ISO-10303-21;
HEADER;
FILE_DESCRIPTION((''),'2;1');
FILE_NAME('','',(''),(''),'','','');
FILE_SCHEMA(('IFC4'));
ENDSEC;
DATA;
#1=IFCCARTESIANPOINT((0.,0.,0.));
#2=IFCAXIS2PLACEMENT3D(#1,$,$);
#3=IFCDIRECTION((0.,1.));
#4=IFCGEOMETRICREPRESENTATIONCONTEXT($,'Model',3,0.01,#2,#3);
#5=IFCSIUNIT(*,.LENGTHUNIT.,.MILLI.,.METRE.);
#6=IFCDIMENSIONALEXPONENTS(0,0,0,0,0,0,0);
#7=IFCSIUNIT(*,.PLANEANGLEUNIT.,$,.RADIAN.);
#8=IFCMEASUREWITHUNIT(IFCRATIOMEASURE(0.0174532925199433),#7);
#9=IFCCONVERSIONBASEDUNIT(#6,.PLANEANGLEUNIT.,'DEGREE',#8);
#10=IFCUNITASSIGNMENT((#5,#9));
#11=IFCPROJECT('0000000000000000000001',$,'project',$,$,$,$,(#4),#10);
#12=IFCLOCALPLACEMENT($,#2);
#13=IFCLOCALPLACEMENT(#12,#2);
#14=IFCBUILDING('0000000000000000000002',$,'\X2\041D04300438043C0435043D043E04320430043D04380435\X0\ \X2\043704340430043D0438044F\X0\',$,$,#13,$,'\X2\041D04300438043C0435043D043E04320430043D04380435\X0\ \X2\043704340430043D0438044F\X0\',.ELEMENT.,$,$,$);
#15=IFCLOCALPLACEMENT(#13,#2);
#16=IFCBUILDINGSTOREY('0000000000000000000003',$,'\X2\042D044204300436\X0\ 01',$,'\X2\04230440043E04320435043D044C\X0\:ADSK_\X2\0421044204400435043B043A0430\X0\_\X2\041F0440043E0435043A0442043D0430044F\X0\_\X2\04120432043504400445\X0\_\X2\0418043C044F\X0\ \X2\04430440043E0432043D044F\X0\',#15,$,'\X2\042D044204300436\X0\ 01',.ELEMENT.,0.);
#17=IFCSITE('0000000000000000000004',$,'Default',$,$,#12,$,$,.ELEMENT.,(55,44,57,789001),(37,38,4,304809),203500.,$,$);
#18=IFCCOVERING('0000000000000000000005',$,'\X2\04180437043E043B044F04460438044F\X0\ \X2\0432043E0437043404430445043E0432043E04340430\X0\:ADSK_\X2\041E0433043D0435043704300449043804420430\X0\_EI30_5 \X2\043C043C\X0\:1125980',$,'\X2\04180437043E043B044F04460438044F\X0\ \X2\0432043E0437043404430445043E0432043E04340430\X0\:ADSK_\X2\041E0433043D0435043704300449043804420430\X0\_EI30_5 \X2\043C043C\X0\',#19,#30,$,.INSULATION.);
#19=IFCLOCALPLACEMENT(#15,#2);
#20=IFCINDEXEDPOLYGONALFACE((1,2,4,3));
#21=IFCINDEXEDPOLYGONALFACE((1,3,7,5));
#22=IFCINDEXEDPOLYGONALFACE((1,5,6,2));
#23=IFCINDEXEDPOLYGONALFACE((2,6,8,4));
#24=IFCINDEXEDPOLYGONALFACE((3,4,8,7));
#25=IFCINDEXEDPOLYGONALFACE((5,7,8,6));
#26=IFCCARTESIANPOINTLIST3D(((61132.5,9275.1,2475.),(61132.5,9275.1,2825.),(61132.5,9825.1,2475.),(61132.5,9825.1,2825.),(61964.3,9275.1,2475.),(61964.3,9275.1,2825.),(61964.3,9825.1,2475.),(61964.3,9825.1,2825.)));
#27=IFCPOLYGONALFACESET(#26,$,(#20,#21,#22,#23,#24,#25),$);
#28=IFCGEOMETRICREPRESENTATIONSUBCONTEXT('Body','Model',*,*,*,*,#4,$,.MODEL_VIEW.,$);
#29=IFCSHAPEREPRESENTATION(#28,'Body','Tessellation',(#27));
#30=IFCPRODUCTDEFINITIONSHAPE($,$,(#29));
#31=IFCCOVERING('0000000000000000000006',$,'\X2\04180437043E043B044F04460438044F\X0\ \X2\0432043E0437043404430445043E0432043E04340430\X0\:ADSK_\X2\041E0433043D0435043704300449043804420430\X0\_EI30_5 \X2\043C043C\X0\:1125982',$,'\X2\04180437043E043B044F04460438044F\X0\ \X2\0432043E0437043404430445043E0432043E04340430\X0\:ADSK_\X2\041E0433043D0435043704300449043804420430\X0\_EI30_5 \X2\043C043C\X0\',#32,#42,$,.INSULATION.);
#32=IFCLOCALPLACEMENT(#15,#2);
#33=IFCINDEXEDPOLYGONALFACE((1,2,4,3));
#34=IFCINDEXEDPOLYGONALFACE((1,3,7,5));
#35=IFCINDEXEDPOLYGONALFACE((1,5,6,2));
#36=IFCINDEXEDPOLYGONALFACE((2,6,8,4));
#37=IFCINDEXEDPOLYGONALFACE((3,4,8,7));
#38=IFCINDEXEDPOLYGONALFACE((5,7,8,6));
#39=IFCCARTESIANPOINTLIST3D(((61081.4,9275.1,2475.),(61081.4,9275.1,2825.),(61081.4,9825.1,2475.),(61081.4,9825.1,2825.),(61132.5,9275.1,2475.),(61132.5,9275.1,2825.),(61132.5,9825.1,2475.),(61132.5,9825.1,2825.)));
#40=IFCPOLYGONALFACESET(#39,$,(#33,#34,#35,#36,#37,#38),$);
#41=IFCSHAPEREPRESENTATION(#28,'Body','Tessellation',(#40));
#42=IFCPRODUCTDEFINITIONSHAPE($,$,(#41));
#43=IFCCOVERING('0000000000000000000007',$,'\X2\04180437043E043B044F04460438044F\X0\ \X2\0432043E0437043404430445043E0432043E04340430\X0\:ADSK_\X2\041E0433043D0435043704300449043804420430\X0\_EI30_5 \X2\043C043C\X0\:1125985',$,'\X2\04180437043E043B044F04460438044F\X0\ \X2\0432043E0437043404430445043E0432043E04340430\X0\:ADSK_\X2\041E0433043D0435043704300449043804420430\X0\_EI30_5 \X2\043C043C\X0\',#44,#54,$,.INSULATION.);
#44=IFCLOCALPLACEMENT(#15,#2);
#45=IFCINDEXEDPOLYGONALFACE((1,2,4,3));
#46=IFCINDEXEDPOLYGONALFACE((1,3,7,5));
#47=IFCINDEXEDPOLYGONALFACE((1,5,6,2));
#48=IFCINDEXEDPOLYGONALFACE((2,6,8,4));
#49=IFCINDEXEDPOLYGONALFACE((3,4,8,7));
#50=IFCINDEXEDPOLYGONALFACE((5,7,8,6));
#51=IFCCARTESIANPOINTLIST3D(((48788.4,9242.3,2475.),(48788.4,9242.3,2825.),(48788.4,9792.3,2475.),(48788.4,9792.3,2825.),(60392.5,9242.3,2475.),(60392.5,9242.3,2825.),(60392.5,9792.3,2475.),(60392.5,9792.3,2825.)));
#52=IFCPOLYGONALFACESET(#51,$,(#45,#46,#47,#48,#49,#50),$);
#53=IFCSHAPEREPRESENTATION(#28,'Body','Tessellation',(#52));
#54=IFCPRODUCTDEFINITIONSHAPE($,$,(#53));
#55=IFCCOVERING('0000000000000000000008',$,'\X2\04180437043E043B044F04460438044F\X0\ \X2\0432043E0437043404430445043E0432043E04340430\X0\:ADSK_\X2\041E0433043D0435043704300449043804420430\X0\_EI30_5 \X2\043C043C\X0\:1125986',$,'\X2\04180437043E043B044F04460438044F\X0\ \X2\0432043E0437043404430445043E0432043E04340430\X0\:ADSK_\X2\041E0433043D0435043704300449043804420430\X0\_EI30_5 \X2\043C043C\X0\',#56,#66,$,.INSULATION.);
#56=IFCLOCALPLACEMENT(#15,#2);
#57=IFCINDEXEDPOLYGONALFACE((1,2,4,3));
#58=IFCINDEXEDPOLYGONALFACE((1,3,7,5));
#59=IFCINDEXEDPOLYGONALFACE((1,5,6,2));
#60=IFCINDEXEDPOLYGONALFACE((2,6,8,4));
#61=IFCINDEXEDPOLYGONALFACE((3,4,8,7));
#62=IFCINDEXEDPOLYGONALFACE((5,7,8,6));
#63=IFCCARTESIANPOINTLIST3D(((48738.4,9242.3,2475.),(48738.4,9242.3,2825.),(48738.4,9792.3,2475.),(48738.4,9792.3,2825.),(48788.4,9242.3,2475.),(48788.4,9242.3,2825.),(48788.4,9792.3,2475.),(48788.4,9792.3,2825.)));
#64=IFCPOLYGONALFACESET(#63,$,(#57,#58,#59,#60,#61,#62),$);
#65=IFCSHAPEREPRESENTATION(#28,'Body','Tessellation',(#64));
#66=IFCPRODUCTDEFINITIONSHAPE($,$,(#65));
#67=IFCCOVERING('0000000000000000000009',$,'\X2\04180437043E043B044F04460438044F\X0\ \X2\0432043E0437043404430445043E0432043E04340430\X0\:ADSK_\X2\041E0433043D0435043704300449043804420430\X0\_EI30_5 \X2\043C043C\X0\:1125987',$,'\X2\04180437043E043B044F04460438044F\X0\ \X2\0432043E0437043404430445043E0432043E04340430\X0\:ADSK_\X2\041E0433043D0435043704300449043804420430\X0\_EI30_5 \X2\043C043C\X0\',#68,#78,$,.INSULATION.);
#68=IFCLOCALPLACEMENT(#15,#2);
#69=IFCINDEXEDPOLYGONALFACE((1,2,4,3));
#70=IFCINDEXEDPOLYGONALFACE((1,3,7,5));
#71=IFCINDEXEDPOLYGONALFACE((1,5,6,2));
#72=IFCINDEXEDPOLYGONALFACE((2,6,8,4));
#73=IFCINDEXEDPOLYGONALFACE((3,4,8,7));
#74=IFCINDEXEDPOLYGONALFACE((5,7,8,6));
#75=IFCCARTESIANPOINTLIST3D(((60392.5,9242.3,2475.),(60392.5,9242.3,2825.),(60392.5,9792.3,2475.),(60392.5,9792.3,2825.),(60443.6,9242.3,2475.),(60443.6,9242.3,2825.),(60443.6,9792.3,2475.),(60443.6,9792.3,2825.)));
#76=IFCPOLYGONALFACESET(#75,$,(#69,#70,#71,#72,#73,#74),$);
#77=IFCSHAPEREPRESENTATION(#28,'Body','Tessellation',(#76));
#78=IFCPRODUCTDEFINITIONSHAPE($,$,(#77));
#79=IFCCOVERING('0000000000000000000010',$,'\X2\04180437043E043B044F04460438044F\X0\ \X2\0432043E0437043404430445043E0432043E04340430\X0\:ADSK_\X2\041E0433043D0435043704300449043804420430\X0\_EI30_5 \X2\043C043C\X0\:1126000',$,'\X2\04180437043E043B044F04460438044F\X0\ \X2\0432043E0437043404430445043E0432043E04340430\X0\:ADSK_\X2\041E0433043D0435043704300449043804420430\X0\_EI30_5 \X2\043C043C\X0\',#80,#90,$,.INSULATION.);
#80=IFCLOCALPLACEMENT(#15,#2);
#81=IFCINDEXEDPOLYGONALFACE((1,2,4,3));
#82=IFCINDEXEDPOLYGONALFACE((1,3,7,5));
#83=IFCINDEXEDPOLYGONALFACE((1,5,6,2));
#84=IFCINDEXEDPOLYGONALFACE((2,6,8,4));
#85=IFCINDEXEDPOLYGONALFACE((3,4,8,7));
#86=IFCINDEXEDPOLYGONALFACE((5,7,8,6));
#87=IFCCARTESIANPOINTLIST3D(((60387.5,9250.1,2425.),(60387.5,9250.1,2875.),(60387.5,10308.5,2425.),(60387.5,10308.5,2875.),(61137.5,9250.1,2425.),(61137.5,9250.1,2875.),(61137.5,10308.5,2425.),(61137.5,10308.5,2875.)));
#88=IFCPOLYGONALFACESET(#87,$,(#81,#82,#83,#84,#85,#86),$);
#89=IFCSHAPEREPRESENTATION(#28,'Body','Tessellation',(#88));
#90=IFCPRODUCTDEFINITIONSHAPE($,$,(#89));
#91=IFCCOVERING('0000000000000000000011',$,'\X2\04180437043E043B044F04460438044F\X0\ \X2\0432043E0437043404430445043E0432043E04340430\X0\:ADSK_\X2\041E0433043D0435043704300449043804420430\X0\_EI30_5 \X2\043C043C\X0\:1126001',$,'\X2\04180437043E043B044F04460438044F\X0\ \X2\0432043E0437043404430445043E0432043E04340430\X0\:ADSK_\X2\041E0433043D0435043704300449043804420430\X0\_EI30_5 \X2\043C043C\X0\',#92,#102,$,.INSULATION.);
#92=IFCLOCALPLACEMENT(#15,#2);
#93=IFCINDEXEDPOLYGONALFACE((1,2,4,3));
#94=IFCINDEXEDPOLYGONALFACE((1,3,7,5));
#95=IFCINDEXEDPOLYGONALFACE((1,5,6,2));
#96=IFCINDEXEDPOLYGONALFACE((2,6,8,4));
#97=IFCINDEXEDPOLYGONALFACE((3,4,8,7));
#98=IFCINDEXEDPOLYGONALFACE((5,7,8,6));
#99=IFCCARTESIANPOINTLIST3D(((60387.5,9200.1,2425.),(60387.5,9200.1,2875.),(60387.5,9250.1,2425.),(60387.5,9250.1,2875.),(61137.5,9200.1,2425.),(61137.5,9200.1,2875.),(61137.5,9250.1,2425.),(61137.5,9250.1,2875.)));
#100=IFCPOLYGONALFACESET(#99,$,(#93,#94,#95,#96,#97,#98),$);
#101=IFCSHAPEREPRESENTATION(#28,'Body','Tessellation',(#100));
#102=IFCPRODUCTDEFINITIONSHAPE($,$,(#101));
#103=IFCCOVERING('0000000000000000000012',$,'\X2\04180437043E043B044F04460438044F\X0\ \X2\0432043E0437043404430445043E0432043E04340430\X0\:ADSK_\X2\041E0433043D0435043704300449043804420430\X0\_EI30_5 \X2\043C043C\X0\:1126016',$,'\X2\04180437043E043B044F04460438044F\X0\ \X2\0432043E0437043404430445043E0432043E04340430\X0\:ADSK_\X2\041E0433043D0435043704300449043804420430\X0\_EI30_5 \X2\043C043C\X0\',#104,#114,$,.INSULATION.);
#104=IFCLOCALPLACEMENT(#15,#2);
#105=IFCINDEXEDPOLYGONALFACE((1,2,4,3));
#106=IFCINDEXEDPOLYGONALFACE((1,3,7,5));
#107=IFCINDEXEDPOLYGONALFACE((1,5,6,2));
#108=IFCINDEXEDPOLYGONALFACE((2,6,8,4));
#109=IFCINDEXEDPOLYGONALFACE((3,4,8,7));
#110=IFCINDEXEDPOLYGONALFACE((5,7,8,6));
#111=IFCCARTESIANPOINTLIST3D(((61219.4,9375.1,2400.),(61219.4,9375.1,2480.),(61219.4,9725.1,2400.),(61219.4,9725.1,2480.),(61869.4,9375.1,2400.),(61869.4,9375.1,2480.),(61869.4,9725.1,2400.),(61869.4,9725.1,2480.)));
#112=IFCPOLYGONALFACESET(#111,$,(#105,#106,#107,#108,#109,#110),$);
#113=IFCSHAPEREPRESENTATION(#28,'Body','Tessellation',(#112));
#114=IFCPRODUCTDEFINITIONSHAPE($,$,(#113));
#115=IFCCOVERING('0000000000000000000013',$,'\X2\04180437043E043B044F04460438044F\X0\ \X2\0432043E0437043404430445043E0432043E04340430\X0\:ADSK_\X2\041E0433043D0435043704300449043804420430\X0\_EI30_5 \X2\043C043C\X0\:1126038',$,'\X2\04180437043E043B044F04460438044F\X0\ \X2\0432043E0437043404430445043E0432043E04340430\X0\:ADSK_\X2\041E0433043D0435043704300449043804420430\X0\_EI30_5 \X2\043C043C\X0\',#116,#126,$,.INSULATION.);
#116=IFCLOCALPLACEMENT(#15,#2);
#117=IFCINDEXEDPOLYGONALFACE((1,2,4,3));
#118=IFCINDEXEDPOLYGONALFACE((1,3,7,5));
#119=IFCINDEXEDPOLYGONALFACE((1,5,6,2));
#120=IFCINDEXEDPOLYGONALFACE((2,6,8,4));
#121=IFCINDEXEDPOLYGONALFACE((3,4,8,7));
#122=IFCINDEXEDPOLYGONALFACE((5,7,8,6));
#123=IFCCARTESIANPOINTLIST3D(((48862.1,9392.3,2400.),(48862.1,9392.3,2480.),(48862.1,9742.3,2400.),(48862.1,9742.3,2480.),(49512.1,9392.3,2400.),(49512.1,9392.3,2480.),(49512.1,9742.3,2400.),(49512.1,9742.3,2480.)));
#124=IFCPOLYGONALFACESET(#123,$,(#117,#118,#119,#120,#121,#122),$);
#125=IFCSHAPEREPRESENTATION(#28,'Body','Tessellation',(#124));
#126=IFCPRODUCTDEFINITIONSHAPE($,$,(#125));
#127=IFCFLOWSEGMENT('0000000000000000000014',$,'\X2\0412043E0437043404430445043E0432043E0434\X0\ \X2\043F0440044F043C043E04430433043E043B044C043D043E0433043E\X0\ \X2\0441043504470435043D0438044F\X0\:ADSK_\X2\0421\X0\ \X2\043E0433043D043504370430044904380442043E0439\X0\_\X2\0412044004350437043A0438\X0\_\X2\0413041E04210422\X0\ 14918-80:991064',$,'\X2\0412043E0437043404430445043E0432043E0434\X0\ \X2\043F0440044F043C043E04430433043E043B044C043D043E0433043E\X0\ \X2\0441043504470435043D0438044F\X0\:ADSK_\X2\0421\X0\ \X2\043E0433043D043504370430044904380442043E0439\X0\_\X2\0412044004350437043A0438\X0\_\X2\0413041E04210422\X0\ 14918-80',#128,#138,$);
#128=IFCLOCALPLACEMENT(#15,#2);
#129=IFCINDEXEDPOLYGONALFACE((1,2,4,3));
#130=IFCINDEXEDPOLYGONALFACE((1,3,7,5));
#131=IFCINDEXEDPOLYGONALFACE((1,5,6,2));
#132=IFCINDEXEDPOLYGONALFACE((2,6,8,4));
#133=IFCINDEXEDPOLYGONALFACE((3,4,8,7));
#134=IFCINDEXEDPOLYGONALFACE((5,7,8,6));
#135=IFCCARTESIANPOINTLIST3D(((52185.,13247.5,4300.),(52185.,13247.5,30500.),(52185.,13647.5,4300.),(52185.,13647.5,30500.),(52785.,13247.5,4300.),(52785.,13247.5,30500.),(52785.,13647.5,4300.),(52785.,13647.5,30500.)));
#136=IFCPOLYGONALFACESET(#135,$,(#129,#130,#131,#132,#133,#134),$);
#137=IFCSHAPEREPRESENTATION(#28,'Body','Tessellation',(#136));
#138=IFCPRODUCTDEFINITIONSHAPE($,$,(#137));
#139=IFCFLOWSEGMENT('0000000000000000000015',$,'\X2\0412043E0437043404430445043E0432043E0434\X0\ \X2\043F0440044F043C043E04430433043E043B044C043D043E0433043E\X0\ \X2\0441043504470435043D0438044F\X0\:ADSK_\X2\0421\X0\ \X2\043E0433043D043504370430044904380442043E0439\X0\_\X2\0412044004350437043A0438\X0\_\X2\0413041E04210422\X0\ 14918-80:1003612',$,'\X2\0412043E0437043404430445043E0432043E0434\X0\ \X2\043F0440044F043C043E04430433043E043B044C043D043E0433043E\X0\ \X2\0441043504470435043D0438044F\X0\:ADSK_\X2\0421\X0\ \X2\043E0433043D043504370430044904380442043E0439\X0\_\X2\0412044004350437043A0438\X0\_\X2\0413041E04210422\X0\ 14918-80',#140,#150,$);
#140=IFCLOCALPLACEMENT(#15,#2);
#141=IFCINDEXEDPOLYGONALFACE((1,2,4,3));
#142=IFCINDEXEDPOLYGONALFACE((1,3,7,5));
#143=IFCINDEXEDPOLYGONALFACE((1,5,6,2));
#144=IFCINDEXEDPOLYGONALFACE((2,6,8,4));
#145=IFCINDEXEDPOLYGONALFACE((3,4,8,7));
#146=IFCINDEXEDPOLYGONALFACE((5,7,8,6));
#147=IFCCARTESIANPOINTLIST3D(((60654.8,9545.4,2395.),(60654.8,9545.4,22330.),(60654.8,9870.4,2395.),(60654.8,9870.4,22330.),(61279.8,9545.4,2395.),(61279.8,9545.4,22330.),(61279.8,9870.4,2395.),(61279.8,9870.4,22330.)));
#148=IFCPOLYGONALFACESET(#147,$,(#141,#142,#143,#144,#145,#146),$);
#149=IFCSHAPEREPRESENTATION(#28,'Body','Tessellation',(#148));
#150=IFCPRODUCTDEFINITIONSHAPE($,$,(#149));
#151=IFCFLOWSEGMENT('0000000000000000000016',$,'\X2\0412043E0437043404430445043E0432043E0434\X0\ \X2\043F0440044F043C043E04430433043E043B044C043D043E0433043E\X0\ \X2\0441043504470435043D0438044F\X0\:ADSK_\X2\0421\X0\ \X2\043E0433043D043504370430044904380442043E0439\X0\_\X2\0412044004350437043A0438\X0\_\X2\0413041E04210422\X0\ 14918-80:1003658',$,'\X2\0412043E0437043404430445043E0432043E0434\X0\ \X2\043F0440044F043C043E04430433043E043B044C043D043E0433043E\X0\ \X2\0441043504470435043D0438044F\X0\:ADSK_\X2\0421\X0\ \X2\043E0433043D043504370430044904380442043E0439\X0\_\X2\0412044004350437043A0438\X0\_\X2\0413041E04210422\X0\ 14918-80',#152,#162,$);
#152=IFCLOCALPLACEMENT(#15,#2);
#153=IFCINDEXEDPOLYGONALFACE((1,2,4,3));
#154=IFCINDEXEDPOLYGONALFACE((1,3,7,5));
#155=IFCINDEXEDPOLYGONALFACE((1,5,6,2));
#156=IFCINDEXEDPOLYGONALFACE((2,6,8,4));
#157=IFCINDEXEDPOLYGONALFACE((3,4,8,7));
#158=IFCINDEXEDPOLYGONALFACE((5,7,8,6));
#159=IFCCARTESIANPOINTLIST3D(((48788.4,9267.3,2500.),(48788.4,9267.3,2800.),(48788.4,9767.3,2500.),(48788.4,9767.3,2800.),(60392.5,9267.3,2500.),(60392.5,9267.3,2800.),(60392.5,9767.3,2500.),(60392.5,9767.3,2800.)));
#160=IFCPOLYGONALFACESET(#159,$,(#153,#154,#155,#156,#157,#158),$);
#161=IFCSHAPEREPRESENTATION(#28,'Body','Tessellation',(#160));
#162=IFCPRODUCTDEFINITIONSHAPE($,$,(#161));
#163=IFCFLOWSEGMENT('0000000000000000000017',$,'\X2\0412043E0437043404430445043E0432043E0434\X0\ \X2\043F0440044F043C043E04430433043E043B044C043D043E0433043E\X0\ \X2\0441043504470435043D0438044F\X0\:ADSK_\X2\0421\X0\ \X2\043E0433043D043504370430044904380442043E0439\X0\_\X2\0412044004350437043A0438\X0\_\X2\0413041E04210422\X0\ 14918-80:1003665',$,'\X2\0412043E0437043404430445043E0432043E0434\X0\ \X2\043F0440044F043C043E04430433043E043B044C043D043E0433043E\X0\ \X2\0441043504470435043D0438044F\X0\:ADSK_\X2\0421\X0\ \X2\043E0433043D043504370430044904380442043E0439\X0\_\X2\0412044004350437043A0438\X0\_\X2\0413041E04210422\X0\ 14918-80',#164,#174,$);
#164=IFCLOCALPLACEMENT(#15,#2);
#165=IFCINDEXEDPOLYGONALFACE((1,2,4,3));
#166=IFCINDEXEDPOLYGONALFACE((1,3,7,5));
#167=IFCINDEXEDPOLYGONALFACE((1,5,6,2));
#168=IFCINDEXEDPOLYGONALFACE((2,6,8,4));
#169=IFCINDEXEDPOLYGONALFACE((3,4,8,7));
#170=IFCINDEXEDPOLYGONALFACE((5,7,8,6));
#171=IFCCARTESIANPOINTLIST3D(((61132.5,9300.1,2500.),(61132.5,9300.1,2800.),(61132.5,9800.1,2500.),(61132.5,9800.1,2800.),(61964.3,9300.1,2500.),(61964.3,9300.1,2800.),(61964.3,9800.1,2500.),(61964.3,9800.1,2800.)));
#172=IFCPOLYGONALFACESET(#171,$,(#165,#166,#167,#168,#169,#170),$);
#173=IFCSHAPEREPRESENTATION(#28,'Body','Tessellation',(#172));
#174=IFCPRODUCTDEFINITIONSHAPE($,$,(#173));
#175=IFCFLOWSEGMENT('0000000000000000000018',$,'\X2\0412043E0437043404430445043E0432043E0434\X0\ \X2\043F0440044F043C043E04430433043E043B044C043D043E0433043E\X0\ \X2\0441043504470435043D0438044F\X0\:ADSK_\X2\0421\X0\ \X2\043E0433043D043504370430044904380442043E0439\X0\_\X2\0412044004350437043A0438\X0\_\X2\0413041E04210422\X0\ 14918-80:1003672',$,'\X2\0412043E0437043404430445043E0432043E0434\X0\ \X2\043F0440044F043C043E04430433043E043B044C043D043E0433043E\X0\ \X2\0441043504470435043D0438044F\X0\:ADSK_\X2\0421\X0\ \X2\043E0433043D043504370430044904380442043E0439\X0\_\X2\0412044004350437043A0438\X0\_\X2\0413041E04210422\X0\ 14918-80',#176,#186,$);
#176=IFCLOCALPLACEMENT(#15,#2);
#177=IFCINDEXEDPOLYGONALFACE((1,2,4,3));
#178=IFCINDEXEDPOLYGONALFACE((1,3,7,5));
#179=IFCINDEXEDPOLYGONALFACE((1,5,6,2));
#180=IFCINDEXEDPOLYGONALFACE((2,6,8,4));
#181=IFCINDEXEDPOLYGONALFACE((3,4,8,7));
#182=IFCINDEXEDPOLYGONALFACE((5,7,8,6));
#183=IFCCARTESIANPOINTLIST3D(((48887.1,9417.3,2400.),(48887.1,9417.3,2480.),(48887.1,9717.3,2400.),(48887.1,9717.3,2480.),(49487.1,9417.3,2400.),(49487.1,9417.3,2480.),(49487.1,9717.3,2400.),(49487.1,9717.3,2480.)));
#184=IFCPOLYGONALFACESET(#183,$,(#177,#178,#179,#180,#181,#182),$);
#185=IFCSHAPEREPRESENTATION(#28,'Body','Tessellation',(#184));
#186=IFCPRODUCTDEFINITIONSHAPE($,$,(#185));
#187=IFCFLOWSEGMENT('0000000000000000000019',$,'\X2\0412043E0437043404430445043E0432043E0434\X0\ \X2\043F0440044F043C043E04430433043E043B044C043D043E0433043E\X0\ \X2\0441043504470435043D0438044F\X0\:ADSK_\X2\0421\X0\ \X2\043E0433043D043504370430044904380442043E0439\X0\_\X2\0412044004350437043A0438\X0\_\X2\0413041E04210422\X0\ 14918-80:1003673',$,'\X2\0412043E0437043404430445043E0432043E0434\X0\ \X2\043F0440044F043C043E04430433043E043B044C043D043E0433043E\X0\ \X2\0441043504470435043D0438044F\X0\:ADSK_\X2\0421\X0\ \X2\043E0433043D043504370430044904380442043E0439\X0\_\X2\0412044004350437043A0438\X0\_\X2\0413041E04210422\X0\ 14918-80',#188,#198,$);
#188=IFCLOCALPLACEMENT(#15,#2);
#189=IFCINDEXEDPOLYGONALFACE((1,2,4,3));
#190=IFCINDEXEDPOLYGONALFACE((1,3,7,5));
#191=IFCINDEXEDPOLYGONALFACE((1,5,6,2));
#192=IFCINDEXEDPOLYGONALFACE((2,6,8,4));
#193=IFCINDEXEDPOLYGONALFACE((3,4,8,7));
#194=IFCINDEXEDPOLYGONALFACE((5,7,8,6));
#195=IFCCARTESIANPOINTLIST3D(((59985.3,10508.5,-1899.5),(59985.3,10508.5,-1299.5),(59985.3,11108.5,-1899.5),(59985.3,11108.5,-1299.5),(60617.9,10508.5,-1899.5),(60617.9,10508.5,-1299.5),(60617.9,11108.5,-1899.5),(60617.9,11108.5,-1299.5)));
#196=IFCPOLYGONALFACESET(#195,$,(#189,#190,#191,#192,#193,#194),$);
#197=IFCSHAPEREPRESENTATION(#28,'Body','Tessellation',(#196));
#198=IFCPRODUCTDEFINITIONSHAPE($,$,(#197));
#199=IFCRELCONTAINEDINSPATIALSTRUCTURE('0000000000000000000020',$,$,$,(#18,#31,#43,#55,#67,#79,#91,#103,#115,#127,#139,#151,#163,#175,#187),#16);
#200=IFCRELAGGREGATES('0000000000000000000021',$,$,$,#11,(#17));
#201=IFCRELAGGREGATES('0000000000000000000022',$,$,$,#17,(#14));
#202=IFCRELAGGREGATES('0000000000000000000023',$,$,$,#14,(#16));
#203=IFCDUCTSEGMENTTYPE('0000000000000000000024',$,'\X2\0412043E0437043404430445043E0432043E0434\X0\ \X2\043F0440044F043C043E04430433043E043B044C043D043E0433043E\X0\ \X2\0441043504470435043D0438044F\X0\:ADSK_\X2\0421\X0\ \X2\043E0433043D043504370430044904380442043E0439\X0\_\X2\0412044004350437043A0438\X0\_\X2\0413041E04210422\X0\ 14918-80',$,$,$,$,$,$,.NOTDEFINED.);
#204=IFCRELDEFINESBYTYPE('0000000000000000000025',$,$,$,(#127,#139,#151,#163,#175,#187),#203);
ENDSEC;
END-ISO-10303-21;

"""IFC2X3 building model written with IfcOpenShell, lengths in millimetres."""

from ifc_helpers import new_model, entity, si_unit, converted_unit, direction, frame, origin, origin_2d_with_axis, place, context, subcontext, project, spatial, rectangle, extrude, type_object, element, save


model = new_model("IFC2X3")

# Units and contexts
model_context = context("Model", 3, precision=0.01, world=origin(), true_north=direction((0.0, 1.0)))
body_context = subcontext(model_context, "Body", "Model", "MODEL_VIEW")
ifc_project = project(units=[si_unit("LENGTHUNIT", "METRE", prefix="MILLI"), converted_unit("PLANEANGLEUNIT", "DEGREE", entity("IfcRatioMeasure", 0.0174532925199433), si_unit("PLANEANGLEUNIT", "RADIAN"), dimensions=[0, 0, 0, 0, 0, 0, 0])], contexts=[model_context])

# Site, building, storey
site_placement = place(None, origin())
site = spatial("IfcSite", under=ifc_project, at=site_placement, Name="Default", CompositionType="ELEMENT", RefLatitude=(55, 44, 57, 789001), RefLongitude=(37, 38, 4, 304809), RefElevation=203500.0)
building_placement = place(site_placement, origin())
building = spatial("IfcBuilding", under=site, at=building_placement, Name="Наименование здания", LongName="Наименование здания", CompositionType="ELEMENT")
storey_placement = place(building_placement, origin())
storey = spatial("IfcBuildingStorey", under=building, at=storey_placement, Name="Этаж 01", ObjectType="Уровень:ADSK_Стрелка_Проектная_Вверх_Имя уровня", LongName="Этаж 01", CompositionType="ELEMENT", Elevation=0.0)

# Coverings
covering_1_placement = place(storey_placement, frame((61132.5, 9275.1, 2475.0)))
element("IfcCovering", 1, at=covering_1_placement, inside=storey, Name="Изоляция воздуховода:ADSK_Огнезащита_EI30_5 мм:1125980", ObjectType="Изоляция воздуховода:ADSK_Огнезащита_EI30_5 мм", PredefinedType="INSULATION", context=body_context, shape_type="SweptSolid", body=[
    extrude(rectangle(XDim=831.8, YDim=550.0, at=origin_2d_with_axis()), frame((415.9, 275.0, 0.0), z_axis=(0.0, 0.0, 1.0), x_axis=(-1.0, 0.0, 0.0)), (0.0, 0.0, 1.0), 350.0),
])
covering_2_placement = place(storey_placement, frame((61081.4, 9275.1, 2475.0)))
element("IfcCovering", 2, at=covering_2_placement, inside=storey, Name="Изоляция воздуховода:ADSK_Огнезащита_EI30_5 мм:1125982", ObjectType="Изоляция воздуховода:ADSK_Огнезащита_EI30_5 мм", PredefinedType="INSULATION", context=body_context, shape_type="SweptSolid", body=[
    extrude(rectangle(XDim=51.1, YDim=550.0, at=origin_2d_with_axis()), frame((25.6, 275.0, 0.0), z_axis=(0.0, 0.0, 1.0), x_axis=(-1.0, 0.0, 0.0)), (0.0, 0.0, 1.0), 350.0),
])
covering_3_placement = place(storey_placement, frame((48788.4, 9242.3, 2475.0)))
element("IfcCovering", 3, at=covering_3_placement, inside=storey, Name="Изоляция воздуховода:ADSK_Огнезащита_EI30_5 мм:1125985", ObjectType="Изоляция воздуховода:ADSK_Огнезащита_EI30_5 мм", PredefinedType="INSULATION", context=body_context, shape_type="SweptSolid", body=[
    extrude(rectangle(XDim=11604.0, YDim=550.0, at=origin_2d_with_axis()), frame((5802.0, 275.0, 0.0)), (0.0, 0.0, 1.0), 350.0),
])
covering_4_placement = place(storey_placement, frame((48738.4, 9242.3, 2475.0)))
element("IfcCovering", 4, at=covering_4_placement, inside=storey, Name="Изоляция воздуховода:ADSK_Огнезащита_EI30_5 мм:1125986", ObjectType="Изоляция воздуховода:ADSK_Огнезащита_EI30_5 мм", PredefinedType="INSULATION", context=body_context, shape_type="SweptSolid", body=[
    extrude(rectangle(XDim=50.0, YDim=550.0, at=origin_2d_with_axis()), frame((25.0, 275.0, 0.0)), (0.0, 0.0, 1.0), 350.0),
])
covering_5_placement = place(storey_placement, frame((60392.5, 9242.3, 2475.0)))
element("IfcCovering", 5, at=covering_5_placement, inside=storey, Name="Изоляция воздуховода:ADSK_Огнезащита_EI30_5 мм:1125987", ObjectType="Изоляция воздуховода:ADSK_Огнезащита_EI30_5 мм", PredefinedType="INSULATION", context=body_context, shape_type="SweptSolid", body=[
    extrude(rectangle(XDim=550.0, YDim=51.1, at=origin_2d_with_axis()), frame((25.6, 275.0, 0.0), z_axis=(0.0, 0.0, 1.0), x_axis=(0.0, -1.0, 0.0)), (0.0, 0.0, 1.0), 350.0),
])
covering_6_placement = place(storey_placement, frame((60387.5, 9250.1, 2425.0)))
element("IfcCovering", 6, at=covering_6_placement, inside=storey, Name="Изоляция воздуховода:ADSK_Огнезащита_EI30_5 мм:1126000", ObjectType="Изоляция воздуховода:ADSK_Огнезащита_EI30_5 мм", PredefinedType="INSULATION", context=body_context, shape_type="SweptSolid", body=[
    extrude(rectangle(XDim=1058.4, YDim=750.0, at=origin_2d_with_axis()), frame((375.0, 529.2, 0.0), z_axis=(0.0, 0.0, 1.0), x_axis=(0.0, -1.0, 0.0)), (0.0, 0.0, 1.0), 450.0),
])
covering_7_placement = place(storey_placement, frame((60387.5, 9200.1, 2425.0)))
element("IfcCovering", 7, at=covering_7_placement, inside=storey, Name="Изоляция воздуховода:ADSK_Огнезащита_EI30_5 мм:1126001", ObjectType="Изоляция воздуховода:ADSK_Огнезащита_EI30_5 мм", PredefinedType="INSULATION", context=body_context, shape_type="SweptSolid", body=[
    extrude(rectangle(XDim=50.0, YDim=750.0, at=origin_2d_with_axis()), frame((375.0, 25.0, 0.0), z_axis=(0.0, 0.0, 1.0), x_axis=(0.0, 1.0, 0.0)), (0.0, 0.0, 1.0), 450.0),
])
covering_8_placement = place(storey_placement, frame((61219.3, 9375.1, 2400.0)))
element("IfcCovering", 8, at=covering_8_placement, inside=storey, Name="Изоляция воздуховода:ADSK_Огнезащита_EI30_5 мм:1126016", ObjectType="Изоляция воздуховода:ADSK_Огнезащита_EI30_5 мм", PredefinedType="INSULATION", context=body_context, shape_type="SweptSolid", body=[
    extrude(rectangle(XDim=650.0, YDim=350.0, at=origin_2d_with_axis()), frame((325.0, 175.0, 0.0), z_axis=(0.0, 0.0, 1.0), x_axis=(-1.0, 0.0, 0.0)), (0.0, 0.0, 1.0), 80.0),
])
covering_9_placement = place(storey_placement, frame((48862.1, 9392.3, 2400.0)))
element("IfcCovering", 9, at=covering_9_placement, inside=storey, Name="Изоляция воздуховода:ADSK_Огнезащита_EI30_5 мм:1126038", ObjectType="Изоляция воздуховода:ADSK_Огнезащита_EI30_5 мм", PredefinedType="INSULATION", context=body_context, shape_type="SweptSolid", body=[
    extrude(rectangle(XDim=650.0, YDim=350.0, at=origin_2d_with_axis()), frame((325.0, 175.0, 0.0), z_axis=(0.0, 0.0, 1.0), x_axis=(-1.0, 0.0, 0.0)), (0.0, 0.0, 1.0), 80.0),
])

# Flow segments
duct_segment_type = type_object("IfcDuctSegmentType", Name="Воздуховод прямоугольного сечения:ADSK_С огнезащитой_Врезки_ГОСТ 14918-80", PredefinedType="NOTDEFINED")
flow_segment_1_placement = place(storey_placement, frame((52185.0, 13247.5, 4300.0)))
element("IfcFlowSegment", 10, at=flow_segment_1_placement, inside=storey, type_object=duct_segment_type, Name="Воздуховод прямоугольного сечения:ADSK_С огнезащитой_Врезки_ГОСТ 14918-80:991064", ObjectType="Воздуховод прямоугольного сечения:ADSK_С огнезащитой_Врезки_ГОСТ 14918-80", context=body_context, shape_type="SweptSolid", body=[
    extrude(rectangle(XDim=400.0, YDim=600.0, at=origin_2d_with_axis()), frame((300.0, 200.0, 0.0), z_axis=(0.0, 0.0, 1.0), x_axis=(0.0, 1.0, 0.0)), (0.0, 0.0, 1.0), 26200.0),
])
flow_segment_2_placement = place(storey_placement, frame((60654.8, 9545.5, 2395.0)))
element("IfcFlowSegment", 11, at=flow_segment_2_placement, inside=storey, type_object=duct_segment_type, Name="Воздуховод прямоугольного сечения:ADSK_С огнезащитой_Врезки_ГОСТ 14918-80:1003612", ObjectType="Воздуховод прямоугольного сечения:ADSK_С огнезащитой_Врезки_ГОСТ 14918-80", context=body_context, shape_type="SweptSolid", body=[
    extrude(rectangle(XDim=625.0, YDim=325.0, at=origin_2d_with_axis()), frame((312.5, 162.5, 0.0), z_axis=(0.0, 0.0, 1.0), x_axis=(-1.0, 0.0, 0.0)), (0.0, 0.0, 1.0), 19935.0),
])
flow_segment_3_placement = place(storey_placement, frame((48788.4, 9267.3, 2500.0)))
element("IfcFlowSegment", 12, at=flow_segment_3_placement, inside=storey, type_object=duct_segment_type, Name="Воздуховод прямоугольного сечения:ADSK_С огнезащитой_Врезки_ГОСТ 14918-80:1003658", ObjectType="Воздуховод прямоугольного сечения:ADSK_С огнезащитой_Врезки_ГОСТ 14918-80", context=body_context, shape_type="SweptSolid", body=[
    extrude(rectangle(XDim=11604.0, YDim=500.0, at=origin_2d_with_axis()), frame((5802.0, 250.0, 0.0)), (0.0, 0.0, 1.0), 300.0),
])
flow_segment_4_placement = place(storey_placement, frame((61132.5, 9300.1, 2500.0)))
element("IfcFlowSegment", 13, at=flow_segment_4_placement, inside=storey, type_object=duct_segment_type, Name="Воздуховод прямоугольного сечения:ADSK_С огнезащитой_Врезки_ГОСТ 14918-80:1003665", ObjectType="Воздуховод прямоугольного сечения:ADSK_С огнезащитой_Врезки_ГОСТ 14918-80", context=body_context, shape_type="SweptSolid", body=[
    extrude(rectangle(XDim=831.8, YDim=500.0, at=origin_2d_with_axis()), frame((415.9, 250.0, 0.0), z_axis=(0.0, 0.0, 1.0), x_axis=(-1.0, 0.0, 0.0)), (0.0, 0.0, 1.0), 300.0),
])
flow_segment_5_placement = place(storey_placement, frame((48887.1, 9417.3, 2400.0)))
element("IfcFlowSegment", 14, at=flow_segment_5_placement, inside=storey, type_object=duct_segment_type, Name="Воздуховод прямоугольного сечения:ADSK_С огнезащитой_Врезки_ГОСТ 14918-80:1003672", ObjectType="Воздуховод прямоугольного сечения:ADSK_С огнезащитой_Врезки_ГОСТ 14918-80", context=body_context, shape_type="SweptSolid", body=[
    extrude(rectangle(XDim=600.0, YDim=300.0, at=origin_2d_with_axis()), frame((300.0, 150.0, 0.0)), (0.0, 0.0, 1.0), 80.0),
])
flow_segment_6_placement = place(storey_placement, frame((59985.3, 10508.5, -1899.5)))
element("IfcFlowSegment", 15, at=flow_segment_6_placement, inside=storey, type_object=duct_segment_type, Name="Воздуховод прямоугольного сечения:ADSK_С огнезащитой_Врезки_ГОСТ 14918-80:1003673", ObjectType="Воздуховод прямоугольного сечения:ADSK_С огнезащитой_Врезки_ГОСТ 14918-80", context=body_context, shape_type="SweptSolid", body=[
    extrude(rectangle(XDim=632.6, YDim=600.0, at=origin_2d_with_axis()), frame((316.3, 300.0, 0.0), z_axis=(0.0, 0.0, 1.0), x_axis=(-1.0, 0.0, 0.0)), (0.0, 0.0, 1.0), 600.0),
])

save(model, "model.ifc")
